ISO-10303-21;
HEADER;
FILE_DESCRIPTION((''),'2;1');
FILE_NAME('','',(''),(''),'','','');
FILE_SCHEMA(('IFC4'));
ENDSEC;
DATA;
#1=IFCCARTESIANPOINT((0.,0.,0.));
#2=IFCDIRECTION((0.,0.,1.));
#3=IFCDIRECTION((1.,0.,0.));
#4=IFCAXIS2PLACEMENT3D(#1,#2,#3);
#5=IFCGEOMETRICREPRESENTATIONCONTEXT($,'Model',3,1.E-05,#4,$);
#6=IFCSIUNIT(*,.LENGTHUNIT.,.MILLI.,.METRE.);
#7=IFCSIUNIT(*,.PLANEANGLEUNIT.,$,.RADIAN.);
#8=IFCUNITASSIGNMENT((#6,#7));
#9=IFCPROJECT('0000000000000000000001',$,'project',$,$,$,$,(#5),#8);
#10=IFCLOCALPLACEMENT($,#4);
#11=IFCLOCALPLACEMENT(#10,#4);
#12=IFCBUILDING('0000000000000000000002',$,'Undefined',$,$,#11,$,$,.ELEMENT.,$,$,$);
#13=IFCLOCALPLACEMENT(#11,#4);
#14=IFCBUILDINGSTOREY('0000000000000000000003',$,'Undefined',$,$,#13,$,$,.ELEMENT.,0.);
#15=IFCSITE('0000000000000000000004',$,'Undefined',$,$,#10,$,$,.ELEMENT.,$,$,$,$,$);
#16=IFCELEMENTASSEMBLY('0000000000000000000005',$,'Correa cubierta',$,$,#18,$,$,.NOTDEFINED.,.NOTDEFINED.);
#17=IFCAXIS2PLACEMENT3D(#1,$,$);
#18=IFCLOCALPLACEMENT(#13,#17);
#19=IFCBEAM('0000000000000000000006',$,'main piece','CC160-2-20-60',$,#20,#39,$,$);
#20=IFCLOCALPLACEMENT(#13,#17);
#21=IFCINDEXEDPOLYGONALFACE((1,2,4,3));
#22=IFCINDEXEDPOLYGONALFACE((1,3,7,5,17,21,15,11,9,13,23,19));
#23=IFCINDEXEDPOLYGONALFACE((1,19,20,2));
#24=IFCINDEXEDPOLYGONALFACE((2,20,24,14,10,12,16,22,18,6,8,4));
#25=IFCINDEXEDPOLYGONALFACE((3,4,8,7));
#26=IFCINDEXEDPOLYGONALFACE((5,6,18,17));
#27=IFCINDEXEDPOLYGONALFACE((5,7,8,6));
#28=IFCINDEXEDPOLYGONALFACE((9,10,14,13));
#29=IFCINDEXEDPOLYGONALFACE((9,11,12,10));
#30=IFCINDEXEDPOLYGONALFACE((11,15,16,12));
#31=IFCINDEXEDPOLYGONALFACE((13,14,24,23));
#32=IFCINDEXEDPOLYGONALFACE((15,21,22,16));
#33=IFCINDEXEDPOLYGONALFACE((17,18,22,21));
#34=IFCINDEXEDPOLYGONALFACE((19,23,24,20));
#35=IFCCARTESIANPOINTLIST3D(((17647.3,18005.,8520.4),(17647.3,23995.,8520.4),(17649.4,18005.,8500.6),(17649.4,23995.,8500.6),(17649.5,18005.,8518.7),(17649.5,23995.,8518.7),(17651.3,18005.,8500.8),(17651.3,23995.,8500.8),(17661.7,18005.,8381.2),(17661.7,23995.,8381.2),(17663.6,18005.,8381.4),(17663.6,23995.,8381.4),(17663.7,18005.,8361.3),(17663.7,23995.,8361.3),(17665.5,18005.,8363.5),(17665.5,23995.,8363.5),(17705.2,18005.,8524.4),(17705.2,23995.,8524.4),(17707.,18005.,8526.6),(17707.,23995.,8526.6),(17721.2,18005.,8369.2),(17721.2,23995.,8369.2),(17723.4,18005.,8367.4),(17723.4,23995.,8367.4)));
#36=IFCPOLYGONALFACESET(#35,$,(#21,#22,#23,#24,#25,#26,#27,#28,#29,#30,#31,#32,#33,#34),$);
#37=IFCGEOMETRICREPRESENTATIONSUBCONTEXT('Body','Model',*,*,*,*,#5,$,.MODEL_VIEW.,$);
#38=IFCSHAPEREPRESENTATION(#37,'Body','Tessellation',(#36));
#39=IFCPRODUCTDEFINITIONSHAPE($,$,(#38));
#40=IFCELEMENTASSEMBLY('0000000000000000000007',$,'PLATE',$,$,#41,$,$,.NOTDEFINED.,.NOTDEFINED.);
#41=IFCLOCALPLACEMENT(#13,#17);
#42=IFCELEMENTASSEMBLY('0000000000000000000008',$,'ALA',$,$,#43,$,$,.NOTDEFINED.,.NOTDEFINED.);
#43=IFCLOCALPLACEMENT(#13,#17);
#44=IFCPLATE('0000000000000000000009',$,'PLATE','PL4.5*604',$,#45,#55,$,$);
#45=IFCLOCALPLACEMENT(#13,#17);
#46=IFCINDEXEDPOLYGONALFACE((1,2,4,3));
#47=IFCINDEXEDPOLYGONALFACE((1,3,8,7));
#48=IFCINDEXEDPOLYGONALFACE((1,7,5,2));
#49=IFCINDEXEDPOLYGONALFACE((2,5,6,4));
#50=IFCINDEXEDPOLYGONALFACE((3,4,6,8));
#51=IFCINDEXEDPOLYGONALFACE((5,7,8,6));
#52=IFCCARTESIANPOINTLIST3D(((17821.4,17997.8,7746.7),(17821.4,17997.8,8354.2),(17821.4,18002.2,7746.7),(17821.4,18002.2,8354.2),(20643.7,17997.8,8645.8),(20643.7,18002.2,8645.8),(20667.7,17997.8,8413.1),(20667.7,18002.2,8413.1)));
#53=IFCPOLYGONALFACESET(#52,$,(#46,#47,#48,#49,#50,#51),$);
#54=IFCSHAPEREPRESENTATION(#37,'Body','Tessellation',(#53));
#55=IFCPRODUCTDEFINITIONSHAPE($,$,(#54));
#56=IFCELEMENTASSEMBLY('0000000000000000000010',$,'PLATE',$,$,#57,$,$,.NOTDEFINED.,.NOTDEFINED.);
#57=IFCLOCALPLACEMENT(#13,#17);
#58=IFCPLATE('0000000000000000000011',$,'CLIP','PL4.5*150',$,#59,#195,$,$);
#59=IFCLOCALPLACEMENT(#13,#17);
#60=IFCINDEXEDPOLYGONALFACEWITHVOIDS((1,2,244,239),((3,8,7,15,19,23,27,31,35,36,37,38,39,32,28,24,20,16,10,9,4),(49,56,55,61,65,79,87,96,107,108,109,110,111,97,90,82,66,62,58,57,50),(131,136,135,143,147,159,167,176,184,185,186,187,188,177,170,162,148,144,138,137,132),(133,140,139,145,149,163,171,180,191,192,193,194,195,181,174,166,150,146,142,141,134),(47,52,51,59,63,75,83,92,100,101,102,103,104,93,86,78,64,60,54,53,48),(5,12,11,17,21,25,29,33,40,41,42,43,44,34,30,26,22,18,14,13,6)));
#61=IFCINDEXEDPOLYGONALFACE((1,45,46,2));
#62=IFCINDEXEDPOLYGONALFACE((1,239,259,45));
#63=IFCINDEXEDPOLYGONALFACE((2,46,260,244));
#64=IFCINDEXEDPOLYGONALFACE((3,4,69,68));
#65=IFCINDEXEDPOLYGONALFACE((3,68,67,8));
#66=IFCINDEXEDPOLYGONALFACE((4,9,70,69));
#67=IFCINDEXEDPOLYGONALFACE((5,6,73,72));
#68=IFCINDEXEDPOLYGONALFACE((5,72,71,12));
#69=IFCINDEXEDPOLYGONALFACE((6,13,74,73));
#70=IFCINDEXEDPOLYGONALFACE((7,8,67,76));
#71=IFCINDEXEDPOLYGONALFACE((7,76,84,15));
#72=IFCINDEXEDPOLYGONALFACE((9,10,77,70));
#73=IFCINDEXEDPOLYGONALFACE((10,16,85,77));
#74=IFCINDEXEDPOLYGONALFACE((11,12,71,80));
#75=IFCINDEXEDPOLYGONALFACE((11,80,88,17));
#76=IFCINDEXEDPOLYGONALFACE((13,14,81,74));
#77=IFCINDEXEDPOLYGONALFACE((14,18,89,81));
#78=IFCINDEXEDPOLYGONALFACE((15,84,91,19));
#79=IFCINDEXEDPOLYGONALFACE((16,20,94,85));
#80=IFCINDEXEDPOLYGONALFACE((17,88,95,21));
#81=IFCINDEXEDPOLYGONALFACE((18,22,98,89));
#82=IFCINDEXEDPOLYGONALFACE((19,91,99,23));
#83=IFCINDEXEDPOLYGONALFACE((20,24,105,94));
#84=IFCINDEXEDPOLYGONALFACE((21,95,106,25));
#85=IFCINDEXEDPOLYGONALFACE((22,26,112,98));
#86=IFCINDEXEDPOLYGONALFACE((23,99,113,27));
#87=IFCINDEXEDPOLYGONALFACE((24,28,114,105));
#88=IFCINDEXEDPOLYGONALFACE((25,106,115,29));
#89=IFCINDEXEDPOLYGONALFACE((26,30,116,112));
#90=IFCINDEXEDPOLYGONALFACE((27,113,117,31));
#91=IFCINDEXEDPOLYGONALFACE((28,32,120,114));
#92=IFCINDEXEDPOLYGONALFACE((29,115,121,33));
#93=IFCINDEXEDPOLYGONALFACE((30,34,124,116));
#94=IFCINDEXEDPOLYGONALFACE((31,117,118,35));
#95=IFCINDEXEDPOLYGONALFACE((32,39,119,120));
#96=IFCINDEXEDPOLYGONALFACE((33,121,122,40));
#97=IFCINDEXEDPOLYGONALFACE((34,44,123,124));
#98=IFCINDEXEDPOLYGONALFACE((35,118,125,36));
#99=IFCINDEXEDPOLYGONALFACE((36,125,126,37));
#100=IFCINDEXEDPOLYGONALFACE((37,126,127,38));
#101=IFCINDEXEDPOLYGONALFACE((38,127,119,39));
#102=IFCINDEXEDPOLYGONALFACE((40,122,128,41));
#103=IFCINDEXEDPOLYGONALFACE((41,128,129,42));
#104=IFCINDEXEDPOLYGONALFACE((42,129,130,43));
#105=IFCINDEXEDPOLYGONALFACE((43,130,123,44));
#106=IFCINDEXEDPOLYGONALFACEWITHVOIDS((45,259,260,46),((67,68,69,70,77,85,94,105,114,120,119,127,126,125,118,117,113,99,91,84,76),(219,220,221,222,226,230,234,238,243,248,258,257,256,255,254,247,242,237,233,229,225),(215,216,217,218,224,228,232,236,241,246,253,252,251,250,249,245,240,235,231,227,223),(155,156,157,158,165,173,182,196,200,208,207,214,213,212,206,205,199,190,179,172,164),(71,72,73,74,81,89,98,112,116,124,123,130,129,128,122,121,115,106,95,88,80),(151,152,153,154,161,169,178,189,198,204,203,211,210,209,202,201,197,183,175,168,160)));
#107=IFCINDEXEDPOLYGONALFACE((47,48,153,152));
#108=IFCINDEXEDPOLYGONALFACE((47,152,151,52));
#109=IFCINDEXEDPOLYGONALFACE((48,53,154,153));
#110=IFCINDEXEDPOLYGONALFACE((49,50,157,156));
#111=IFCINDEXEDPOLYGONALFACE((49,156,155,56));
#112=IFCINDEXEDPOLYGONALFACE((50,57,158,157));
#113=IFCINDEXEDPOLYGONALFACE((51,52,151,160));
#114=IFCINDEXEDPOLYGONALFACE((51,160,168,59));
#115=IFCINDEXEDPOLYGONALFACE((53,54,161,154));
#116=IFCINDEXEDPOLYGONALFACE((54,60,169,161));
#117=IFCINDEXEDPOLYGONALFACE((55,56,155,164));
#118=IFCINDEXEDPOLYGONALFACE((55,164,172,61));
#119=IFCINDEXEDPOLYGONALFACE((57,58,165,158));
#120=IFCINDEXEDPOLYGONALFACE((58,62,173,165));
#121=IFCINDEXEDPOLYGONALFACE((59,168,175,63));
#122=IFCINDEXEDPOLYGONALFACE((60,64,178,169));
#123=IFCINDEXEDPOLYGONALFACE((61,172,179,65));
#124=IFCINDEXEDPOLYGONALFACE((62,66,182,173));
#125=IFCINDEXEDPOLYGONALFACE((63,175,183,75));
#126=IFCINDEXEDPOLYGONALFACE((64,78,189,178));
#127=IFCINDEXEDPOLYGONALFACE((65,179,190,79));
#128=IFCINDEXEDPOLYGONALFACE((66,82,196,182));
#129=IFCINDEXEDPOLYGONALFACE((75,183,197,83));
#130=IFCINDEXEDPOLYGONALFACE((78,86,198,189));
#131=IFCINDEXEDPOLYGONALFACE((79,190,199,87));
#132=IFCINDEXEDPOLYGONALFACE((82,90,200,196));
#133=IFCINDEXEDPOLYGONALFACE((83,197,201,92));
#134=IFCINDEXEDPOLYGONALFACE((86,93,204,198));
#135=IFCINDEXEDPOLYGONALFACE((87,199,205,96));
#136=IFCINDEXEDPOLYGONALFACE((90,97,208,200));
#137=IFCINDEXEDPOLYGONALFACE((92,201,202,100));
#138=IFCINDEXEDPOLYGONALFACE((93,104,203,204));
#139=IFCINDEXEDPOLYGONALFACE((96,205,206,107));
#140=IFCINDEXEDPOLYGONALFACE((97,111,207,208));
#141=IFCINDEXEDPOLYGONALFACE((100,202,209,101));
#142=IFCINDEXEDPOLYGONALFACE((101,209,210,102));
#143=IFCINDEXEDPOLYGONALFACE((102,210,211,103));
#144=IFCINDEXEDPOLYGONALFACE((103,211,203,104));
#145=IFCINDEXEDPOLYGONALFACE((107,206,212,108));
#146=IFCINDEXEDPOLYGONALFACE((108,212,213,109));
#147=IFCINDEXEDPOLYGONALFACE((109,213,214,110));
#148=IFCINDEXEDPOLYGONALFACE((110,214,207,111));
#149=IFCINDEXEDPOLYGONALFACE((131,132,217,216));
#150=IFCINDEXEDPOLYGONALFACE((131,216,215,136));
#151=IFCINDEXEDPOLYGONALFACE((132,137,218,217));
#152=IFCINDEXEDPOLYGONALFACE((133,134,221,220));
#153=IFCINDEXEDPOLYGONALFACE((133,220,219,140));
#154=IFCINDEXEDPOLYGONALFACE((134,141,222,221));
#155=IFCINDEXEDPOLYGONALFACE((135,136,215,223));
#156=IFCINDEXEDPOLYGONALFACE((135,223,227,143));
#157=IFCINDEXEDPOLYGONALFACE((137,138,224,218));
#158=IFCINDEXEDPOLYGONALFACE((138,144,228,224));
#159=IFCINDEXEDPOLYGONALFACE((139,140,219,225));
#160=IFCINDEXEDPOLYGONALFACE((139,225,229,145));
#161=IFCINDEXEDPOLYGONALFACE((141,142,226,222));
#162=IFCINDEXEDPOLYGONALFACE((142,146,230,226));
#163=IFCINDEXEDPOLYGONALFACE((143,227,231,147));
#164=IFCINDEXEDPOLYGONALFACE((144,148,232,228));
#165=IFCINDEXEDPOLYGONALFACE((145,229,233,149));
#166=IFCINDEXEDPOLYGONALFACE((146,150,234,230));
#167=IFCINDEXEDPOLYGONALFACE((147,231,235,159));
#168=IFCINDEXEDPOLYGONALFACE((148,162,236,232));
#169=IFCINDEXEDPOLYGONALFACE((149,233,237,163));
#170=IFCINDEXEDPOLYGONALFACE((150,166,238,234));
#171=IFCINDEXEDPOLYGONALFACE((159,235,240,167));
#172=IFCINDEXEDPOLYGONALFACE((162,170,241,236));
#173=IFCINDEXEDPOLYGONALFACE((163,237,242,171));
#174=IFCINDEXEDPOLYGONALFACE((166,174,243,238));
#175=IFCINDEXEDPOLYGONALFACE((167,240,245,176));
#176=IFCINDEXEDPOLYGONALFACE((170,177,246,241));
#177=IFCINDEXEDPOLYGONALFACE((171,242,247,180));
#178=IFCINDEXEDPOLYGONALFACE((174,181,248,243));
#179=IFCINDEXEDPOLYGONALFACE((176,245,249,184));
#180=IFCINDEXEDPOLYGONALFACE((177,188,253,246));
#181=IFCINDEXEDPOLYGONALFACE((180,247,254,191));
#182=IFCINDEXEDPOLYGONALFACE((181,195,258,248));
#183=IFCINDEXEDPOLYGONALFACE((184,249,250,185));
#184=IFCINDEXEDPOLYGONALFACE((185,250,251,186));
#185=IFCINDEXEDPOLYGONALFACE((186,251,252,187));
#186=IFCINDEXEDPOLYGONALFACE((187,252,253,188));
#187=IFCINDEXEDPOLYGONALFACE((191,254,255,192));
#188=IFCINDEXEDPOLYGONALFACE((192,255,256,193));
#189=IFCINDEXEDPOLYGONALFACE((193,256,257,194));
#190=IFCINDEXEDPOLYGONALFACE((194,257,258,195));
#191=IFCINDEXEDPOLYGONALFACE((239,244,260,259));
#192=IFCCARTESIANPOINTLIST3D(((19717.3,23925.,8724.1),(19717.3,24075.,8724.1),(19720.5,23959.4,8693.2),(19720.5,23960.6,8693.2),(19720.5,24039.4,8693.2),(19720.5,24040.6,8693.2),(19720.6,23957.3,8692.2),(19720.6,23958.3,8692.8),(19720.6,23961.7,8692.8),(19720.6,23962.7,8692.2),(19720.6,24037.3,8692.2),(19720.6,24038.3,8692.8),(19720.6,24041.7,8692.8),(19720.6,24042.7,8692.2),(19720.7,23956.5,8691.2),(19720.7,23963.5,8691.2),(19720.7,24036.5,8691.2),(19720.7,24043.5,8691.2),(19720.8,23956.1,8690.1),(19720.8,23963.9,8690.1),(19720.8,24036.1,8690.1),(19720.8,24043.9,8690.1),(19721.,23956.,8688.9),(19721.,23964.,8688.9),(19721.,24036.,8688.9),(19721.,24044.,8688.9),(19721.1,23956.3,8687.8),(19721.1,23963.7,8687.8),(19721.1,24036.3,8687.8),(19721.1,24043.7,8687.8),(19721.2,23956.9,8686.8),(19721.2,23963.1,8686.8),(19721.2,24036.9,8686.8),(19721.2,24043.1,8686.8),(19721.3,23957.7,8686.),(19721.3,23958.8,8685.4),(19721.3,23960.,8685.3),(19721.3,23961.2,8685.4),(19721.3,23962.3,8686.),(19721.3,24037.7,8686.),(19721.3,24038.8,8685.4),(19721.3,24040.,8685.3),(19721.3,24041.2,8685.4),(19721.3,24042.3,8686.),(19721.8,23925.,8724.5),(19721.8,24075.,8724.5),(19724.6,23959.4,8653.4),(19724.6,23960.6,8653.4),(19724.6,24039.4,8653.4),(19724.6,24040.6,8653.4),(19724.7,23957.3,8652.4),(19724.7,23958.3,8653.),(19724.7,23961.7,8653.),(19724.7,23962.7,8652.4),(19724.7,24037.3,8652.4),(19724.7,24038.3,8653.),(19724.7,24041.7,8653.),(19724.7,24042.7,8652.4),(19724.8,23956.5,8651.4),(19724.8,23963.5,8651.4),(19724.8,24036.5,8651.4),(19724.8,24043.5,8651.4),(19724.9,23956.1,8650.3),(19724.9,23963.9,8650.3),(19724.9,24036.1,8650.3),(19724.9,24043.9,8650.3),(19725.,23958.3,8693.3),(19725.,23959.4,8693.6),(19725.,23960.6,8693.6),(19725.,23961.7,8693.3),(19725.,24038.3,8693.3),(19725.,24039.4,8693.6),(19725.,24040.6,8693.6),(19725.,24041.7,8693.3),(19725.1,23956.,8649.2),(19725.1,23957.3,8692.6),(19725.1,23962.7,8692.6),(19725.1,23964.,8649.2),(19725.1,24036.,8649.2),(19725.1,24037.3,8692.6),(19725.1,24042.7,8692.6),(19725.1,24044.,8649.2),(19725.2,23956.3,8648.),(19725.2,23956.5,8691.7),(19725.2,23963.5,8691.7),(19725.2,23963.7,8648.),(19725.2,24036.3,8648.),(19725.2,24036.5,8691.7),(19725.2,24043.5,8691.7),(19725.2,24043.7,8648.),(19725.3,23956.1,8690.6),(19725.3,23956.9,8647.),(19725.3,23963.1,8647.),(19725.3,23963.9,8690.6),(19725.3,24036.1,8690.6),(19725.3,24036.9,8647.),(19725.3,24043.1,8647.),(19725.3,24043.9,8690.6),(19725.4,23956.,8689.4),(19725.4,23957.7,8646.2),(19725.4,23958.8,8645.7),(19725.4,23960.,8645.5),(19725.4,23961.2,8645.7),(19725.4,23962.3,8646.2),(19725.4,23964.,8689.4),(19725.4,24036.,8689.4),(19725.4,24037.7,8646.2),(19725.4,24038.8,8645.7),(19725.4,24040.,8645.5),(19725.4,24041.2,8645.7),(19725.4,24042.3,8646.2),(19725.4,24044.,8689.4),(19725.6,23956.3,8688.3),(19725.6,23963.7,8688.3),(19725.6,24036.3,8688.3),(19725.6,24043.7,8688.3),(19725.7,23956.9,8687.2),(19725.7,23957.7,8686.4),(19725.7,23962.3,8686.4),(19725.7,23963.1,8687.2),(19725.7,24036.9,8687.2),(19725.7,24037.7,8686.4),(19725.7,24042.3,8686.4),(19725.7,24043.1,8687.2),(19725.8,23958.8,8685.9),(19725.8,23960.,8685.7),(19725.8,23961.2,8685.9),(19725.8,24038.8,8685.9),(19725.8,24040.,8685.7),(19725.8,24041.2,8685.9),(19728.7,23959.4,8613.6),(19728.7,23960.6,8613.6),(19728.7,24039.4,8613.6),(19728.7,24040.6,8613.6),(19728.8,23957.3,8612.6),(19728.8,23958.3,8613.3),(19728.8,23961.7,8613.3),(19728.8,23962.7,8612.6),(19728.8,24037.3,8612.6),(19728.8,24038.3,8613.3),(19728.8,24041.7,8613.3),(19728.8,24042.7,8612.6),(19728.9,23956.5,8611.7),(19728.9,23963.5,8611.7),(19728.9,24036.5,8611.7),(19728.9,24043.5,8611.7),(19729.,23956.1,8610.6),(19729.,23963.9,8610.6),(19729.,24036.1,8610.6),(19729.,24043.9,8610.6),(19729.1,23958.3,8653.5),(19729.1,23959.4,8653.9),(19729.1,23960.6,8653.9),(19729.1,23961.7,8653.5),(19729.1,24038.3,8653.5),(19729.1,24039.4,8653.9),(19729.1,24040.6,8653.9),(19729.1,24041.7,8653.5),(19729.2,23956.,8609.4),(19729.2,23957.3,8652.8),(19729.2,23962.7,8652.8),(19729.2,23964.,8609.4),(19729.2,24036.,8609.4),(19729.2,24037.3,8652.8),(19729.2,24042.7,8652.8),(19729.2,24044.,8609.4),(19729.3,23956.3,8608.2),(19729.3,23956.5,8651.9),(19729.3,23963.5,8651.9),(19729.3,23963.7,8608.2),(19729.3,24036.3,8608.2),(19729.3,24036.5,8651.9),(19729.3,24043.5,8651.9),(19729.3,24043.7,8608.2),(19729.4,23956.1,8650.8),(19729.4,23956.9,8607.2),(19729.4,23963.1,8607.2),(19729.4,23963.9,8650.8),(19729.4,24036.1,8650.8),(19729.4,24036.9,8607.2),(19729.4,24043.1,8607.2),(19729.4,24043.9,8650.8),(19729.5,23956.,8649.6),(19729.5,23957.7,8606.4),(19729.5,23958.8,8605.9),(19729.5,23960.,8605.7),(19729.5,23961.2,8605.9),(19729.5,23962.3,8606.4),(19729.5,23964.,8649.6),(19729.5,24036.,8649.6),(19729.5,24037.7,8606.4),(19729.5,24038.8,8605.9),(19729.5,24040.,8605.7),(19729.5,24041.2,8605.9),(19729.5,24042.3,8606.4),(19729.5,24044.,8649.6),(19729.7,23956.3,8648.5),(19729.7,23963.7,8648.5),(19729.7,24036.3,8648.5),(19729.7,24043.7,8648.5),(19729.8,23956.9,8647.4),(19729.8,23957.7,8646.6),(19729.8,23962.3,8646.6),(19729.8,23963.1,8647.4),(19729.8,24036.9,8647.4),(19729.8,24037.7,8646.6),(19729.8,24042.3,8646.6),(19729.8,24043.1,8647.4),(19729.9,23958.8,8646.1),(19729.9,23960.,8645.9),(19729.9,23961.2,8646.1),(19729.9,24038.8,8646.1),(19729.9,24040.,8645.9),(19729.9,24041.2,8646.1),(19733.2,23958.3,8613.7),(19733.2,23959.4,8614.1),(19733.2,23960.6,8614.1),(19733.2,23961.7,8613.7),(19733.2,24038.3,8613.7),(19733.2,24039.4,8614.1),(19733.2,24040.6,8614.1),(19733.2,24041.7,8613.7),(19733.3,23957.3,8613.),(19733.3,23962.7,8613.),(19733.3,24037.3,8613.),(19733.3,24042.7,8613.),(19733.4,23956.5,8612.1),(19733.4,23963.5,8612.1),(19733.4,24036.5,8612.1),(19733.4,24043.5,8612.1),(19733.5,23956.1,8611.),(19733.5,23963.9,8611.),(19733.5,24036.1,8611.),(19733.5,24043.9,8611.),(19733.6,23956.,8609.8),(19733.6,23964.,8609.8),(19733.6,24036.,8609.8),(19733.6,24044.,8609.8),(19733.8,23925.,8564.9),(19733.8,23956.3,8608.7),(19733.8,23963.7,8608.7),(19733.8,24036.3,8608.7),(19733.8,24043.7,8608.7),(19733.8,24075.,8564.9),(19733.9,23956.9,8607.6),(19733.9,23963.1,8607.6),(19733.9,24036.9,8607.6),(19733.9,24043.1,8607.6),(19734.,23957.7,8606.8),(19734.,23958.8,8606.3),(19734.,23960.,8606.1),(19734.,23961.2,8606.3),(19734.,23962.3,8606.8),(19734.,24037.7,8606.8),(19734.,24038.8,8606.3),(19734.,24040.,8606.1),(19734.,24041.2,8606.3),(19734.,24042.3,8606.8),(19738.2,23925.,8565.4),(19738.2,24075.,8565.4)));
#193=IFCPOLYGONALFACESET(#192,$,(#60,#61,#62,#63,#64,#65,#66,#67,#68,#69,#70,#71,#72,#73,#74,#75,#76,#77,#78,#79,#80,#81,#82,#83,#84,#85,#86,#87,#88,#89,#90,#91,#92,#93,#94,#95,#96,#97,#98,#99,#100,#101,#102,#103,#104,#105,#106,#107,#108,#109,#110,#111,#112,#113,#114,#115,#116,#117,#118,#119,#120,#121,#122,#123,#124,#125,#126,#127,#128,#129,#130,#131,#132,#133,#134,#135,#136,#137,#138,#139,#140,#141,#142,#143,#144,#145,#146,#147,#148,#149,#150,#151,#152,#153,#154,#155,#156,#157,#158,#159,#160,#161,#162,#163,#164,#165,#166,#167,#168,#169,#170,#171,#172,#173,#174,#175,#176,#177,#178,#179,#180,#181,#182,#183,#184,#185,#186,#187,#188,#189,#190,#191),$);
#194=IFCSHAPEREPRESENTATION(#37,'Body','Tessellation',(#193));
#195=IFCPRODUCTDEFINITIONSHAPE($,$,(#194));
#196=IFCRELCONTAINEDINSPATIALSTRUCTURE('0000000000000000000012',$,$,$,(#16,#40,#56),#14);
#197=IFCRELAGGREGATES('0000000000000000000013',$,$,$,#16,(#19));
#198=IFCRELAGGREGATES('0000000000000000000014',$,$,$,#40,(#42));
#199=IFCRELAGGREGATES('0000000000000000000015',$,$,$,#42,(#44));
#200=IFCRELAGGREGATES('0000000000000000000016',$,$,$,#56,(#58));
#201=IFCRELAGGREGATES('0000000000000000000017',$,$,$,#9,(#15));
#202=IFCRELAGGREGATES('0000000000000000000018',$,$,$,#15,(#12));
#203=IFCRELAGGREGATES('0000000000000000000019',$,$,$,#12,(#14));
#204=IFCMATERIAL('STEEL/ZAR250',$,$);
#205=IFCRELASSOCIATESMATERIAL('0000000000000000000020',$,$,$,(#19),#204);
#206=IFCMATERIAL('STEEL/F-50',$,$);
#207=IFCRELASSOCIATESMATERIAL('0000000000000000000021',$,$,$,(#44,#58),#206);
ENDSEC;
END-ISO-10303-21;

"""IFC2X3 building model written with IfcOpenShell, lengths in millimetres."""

from ifc_helpers import new_model, si_unit, frame, origin_with_axes, origin_2d_with_axis, place, context, subcontext, project, spatial, polyline, circle, c_section, outline, extrude, source, transform, mapped, material, element, aggregate, save


model = new_model("IFC2X3")

# Units and contexts
model_context = context("Model", 3, precision=1e-05, world=origin_with_axes())
body_context = subcontext(model_context, "Body", "Model", "MODEL_VIEW")
ifc_project = project(units=[si_unit("LENGTHUNIT", "METRE", prefix="MILLI"), si_unit("PLANEANGLEUNIT", "RADIAN")], contexts=[model_context])

# Site, building, storey
site_placement = place(None, origin_with_axes())
site = spatial("IfcSite", under=ifc_project, at=site_placement, Name="Undefined", CompositionType="ELEMENT")
building_placement = place(site_placement, origin_with_axes())
building = spatial("IfcBuilding", under=site, at=building_placement, Name="Undefined", CompositionType="ELEMENT")
storey_placement = place(building_placement, origin_with_axes())
storey = spatial("IfcBuildingStorey", under=building, at=storey_placement, Name="Undefined", CompositionType="ELEMENT", Elevation=0.0)

# Element assembly, beam
ifc_material_1 = material(Name="STEEL/ZAR250")
assembly_1_placement = place(storey_placement, origin_with_axes())
assembly_1 = element("IfcElementAssembly", 1, at=assembly_1_placement, inside=storey, Name="Correa cubierta", AssemblyPlace="NOTDEFINED", PredefinedType="NOTDEFINED")
beam_1_placement = place(assembly_1_placement, frame((17685.3, 23995.0, 8443.9), z_axis=(-0.102562, 0.0, 0.994727), x_axis=(0.0, -1.0, 0.0)))
beam_1 = element("IfcBeam", 2, at=beam_1_placement, material=ifc_material_1, Name="main piece", Description="CC160-2-20-60", context=body_context, shape_type="SweptSolid", body=[
    extrude(c_section(Depth=160.0, Width=60.0, WallThickness=2.0, Girth=20.0, at=origin_2d_with_axis()), frame((5990.0, 0.0, 0.0), z_axis=(-1.0, 0.0, 0.0), x_axis=(0.0, -1.0, 0.0)), (0.0, 0.0, 1.0), 5990.0),
])
aggregate(assembly_1, [beam_1])

# Element assembly
assembly_2_placement = place(storey_placement, origin_with_axes())
assembly_2 = element("IfcElementAssembly", 3, at=assembly_2_placement, inside=storey, Name="PLATE", AssemblyPlace="NOTDEFINED", PredefinedType="NOTDEFINED")

# Element assembly
assembly_3_placement = place(assembly_2_placement, origin_with_axes())
assembly_3 = element("IfcElementAssembly", 4, at=assembly_3_placement, Name="ALA", AssemblyPlace="NOTDEFINED", PredefinedType="NOTDEFINED")
aggregate(assembly_2, [assembly_3])

# Plate
ifc_material_2 = material(Name="STEEL/F-50")
plate_1_placement = place(assembly_3_placement, frame((20667.7, 18000.0, 8413.1), z_axis=(0.0, -1.0, 0.0), x_axis=(-0.102676, 0.0, 0.994715)))
plate_1 = element("IfcPlate", 5, at=plate_1_placement, material=ifc_material_2, Name="PLATE", Description="PL4.5*604", context=body_context, shape_type="SweptSolid", body=[
    extrude(outline(polyline([(0.0, 0.0), (234.0, 0.0), (233.7, 2837.3), (-370.6, 2899.7), (0.0, 0.0)])), frame((0.0, 0.0, -2.2), z_axis=(0.0, 0.0, 1.0), x_axis=(1.0, 0.0, 0.0)), (0.0, 0.0, 1.0), 4.5),
])
aggregate(assembly_3, [plate_1])

# Element assembly, plate, openings
assembly_4_placement = place(storey_placement, origin_with_axes())
assembly_4 = element("IfcElementAssembly", 6, at=assembly_4_placement, inside=storey, Name="PLATE", AssemblyPlace="NOTDEFINED", PredefinedType="NOTDEFINED")
plate_2_placement = place(assembly_4_placement, frame((19719.6, 23925.0, 8724.3), z_axis=(0.994727, 0.0, 0.102562), x_axis=(0.102562, 0.0, -0.994727)))
plate_2 = element("IfcPlate", 7, at=plate_2_placement, material=ifc_material_2, Name="CLIP", Description="PL4.5*150", context=body_context, shape_type="SweptSolid", body=[
    extrude(outline(polyline([(0.0, 0.0), (160.0, 0.0), (160.0, 150.0), (0.0, 150.0), (0.0, 0.0)])), frame((0.0, 0.0, -2.2), z_axis=(0.0, 0.0, 1.0), x_axis=(1.0, 0.0, 0.0)), (0.0, 0.0, 1.0), 4.5),
])
shared_shape_1 = source(origin_with_axes(), body_context, "Body", "SweptSolid", [
    extrude(circle(Radius=4.0, at=origin_2d_with_axis()), frame((0.0, -4.6, 0.0), z_axis=(0.0, 1.0, 0.0), x_axis=(1.0, 0.0, 0.0)), (0.0, 0.0, 1.0), 4.7),
])
opening_1_placement = place(assembly_4_placement, frame((19720.9, 24040.0, 8689.2), z_axis=(0.0, 1.0, 0.0), x_axis=(0.102562, 0.0, -0.994727)))
element("IfcOpeningElement", 8, at=opening_1_placement, cuts=plate_2, ObjectType="Opening", context=body_context, shape_type="MappedRepresentation", body=[
    mapped(shared_shape_1, transform((0.0, 0.0, 0.0))),
    mapped(shared_shape_1, transform((40.0, 0.0, 0.0))),
    mapped(shared_shape_1, transform((80.0, 0.0, 0.0))),
])
opening_2_placement = place(assembly_4_placement, frame((19720.9, 23960.0, 8689.2), z_axis=(0.0, 1.0, 0.0), x_axis=(0.102562, 0.0, -0.994727)))
element("IfcOpeningElement", 9, at=opening_2_placement, cuts=plate_2, ObjectType="Opening", context=body_context, shape_type="MappedRepresentation", body=[
    mapped(shared_shape_1, transform((0.0, 0.0, 0.0))),
    mapped(shared_shape_1, transform((40.0, 0.0, 0.0))),
    mapped(shared_shape_1, transform((80.0, 0.0, 0.0))),
])

aggregate(assembly_4, [plate_2])

save(model, "model.ifc")
